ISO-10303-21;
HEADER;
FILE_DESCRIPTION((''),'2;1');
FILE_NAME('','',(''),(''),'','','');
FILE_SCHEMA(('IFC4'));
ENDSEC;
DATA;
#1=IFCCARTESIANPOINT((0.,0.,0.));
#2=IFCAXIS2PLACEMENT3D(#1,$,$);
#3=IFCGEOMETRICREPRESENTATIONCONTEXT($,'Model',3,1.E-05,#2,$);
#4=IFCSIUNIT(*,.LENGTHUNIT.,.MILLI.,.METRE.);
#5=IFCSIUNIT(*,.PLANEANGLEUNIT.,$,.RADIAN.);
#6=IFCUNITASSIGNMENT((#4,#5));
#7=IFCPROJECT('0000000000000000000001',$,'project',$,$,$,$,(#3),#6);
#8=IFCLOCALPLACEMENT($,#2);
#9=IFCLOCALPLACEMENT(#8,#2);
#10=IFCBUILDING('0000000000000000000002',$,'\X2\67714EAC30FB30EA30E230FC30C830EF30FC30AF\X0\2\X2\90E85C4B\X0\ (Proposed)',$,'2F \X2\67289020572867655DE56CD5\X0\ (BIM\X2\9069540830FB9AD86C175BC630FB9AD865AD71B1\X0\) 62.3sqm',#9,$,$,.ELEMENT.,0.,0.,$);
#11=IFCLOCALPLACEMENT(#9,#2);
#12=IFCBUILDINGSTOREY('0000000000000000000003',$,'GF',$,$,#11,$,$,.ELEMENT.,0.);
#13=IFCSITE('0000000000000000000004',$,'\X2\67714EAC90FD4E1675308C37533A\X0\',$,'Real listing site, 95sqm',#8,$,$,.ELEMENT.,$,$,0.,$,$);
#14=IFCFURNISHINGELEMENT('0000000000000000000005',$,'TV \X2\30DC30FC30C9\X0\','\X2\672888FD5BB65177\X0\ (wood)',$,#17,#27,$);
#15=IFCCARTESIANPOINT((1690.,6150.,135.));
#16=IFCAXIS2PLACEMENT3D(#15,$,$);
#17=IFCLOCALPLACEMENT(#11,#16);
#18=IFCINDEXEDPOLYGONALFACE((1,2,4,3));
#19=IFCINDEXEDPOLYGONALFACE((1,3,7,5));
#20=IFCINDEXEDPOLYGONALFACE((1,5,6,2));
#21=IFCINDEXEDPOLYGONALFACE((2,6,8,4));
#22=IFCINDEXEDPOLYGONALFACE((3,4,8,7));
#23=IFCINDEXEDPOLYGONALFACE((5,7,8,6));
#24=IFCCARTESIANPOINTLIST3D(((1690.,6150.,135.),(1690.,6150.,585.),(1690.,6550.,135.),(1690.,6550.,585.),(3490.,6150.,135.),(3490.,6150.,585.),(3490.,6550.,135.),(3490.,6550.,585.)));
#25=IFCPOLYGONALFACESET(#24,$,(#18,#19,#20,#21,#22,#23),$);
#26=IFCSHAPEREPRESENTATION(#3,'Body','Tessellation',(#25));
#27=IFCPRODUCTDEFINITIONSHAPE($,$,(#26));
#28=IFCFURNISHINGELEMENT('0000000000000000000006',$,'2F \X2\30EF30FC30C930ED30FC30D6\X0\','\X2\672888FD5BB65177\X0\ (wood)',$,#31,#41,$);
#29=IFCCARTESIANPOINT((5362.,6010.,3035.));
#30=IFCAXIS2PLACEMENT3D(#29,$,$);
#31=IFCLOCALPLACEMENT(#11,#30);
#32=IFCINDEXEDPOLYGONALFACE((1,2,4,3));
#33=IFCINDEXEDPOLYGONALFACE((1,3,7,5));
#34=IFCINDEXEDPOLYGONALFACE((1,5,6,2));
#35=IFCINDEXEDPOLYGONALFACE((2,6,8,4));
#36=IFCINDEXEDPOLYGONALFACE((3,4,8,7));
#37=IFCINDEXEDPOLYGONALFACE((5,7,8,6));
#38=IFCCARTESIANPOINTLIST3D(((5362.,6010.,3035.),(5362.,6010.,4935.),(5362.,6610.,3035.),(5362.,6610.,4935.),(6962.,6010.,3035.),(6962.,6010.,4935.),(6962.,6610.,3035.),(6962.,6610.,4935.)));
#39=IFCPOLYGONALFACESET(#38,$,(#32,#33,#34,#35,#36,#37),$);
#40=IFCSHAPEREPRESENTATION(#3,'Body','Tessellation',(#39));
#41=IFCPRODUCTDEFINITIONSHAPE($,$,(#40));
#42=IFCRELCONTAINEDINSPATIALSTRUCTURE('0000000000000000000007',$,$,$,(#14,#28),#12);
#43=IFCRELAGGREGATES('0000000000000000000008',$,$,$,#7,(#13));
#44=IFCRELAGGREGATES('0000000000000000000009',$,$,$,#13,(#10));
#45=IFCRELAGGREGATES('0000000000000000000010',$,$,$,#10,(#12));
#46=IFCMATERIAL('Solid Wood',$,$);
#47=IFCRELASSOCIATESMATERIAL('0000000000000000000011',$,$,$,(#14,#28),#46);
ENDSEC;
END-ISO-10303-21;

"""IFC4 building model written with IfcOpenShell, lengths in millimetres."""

from ifc_helpers import new_model, si_unit, frame, frame_2d, origin, place, context, project, spatial, rectangle, extrude, material, element, save


model = new_model("IFC4")

# Units and contexts
model_context = context("Model", 3, precision=1e-05, world=origin())
ifc_project = project(units=[si_unit("LENGTHUNIT", "METRE", prefix="MILLI"), si_unit("PLANEANGLEUNIT", "RADIAN")], contexts=[model_context])

# Site, building, storey
site_placement = place(None, origin())
site = spatial("IfcSite", under=ifc_project, at=site_placement, Name="東京都世田谷区", ObjectType="Real listing site, 95sqm", CompositionType="ELEMENT", RefElevation=0.0)
building_placement = place(site_placement, origin())
building = spatial("IfcBuilding", under=site, at=building_placement, Name="東京・リモートワーク2部屋 (Proposed)", ObjectType="2F 木造在来工法 (BIM適合・高気密・高断熱) 62.3sqm", CompositionType="ELEMENT", ElevationOfRefHeight=0.0, ElevationOfTerrain=0.0)
storey_placement = place(building_placement, origin())
storey = spatial("IfcBuildingStorey", under=building, at=storey_placement, Name="GF", CompositionType="ELEMENT", Elevation=0.0)

# Shared definitions
ifc_material_1 = material(Name="Solid Wood")

# Furnishing elements
furnishing_1_placement = place(storey_placement, frame((1690.0, 6150.0, 135.0)))
element("IfcFurnishingElement", 1, at=furnishing_1_placement, inside=storey, material=ifc_material_1, Name="TV ボード", Description="木製家具 (wood)", context=model_context, shape_type="SweptSolid", body=[
    extrude(rectangle(XDim=1800.0, YDim=400.0, at=frame_2d((900.0, 200.0))), frame((1690.0, 6150.0, 135.0)), (0.0, 0.0, 1.0), 450.0),
])
furnishing_2_placement = place(storey_placement, frame((5362.0, 6010.0, 3035.0)))
element("IfcFurnishingElement", 2, at=furnishing_2_placement, inside=storey, material=ifc_material_1, Name="2F ワードローブ", Description="木製家具 (wood)", context=model_context, shape_type="SweptSolid", body=[
    extrude(rectangle(XDim=1600.0, YDim=600.0, at=frame_2d((800.0, 300.0))), frame((5362.0, 6010.0, 3035.0)), (0.0, 0.0, 1.0), 1900.0),
])

save(model, "model.ifc")
